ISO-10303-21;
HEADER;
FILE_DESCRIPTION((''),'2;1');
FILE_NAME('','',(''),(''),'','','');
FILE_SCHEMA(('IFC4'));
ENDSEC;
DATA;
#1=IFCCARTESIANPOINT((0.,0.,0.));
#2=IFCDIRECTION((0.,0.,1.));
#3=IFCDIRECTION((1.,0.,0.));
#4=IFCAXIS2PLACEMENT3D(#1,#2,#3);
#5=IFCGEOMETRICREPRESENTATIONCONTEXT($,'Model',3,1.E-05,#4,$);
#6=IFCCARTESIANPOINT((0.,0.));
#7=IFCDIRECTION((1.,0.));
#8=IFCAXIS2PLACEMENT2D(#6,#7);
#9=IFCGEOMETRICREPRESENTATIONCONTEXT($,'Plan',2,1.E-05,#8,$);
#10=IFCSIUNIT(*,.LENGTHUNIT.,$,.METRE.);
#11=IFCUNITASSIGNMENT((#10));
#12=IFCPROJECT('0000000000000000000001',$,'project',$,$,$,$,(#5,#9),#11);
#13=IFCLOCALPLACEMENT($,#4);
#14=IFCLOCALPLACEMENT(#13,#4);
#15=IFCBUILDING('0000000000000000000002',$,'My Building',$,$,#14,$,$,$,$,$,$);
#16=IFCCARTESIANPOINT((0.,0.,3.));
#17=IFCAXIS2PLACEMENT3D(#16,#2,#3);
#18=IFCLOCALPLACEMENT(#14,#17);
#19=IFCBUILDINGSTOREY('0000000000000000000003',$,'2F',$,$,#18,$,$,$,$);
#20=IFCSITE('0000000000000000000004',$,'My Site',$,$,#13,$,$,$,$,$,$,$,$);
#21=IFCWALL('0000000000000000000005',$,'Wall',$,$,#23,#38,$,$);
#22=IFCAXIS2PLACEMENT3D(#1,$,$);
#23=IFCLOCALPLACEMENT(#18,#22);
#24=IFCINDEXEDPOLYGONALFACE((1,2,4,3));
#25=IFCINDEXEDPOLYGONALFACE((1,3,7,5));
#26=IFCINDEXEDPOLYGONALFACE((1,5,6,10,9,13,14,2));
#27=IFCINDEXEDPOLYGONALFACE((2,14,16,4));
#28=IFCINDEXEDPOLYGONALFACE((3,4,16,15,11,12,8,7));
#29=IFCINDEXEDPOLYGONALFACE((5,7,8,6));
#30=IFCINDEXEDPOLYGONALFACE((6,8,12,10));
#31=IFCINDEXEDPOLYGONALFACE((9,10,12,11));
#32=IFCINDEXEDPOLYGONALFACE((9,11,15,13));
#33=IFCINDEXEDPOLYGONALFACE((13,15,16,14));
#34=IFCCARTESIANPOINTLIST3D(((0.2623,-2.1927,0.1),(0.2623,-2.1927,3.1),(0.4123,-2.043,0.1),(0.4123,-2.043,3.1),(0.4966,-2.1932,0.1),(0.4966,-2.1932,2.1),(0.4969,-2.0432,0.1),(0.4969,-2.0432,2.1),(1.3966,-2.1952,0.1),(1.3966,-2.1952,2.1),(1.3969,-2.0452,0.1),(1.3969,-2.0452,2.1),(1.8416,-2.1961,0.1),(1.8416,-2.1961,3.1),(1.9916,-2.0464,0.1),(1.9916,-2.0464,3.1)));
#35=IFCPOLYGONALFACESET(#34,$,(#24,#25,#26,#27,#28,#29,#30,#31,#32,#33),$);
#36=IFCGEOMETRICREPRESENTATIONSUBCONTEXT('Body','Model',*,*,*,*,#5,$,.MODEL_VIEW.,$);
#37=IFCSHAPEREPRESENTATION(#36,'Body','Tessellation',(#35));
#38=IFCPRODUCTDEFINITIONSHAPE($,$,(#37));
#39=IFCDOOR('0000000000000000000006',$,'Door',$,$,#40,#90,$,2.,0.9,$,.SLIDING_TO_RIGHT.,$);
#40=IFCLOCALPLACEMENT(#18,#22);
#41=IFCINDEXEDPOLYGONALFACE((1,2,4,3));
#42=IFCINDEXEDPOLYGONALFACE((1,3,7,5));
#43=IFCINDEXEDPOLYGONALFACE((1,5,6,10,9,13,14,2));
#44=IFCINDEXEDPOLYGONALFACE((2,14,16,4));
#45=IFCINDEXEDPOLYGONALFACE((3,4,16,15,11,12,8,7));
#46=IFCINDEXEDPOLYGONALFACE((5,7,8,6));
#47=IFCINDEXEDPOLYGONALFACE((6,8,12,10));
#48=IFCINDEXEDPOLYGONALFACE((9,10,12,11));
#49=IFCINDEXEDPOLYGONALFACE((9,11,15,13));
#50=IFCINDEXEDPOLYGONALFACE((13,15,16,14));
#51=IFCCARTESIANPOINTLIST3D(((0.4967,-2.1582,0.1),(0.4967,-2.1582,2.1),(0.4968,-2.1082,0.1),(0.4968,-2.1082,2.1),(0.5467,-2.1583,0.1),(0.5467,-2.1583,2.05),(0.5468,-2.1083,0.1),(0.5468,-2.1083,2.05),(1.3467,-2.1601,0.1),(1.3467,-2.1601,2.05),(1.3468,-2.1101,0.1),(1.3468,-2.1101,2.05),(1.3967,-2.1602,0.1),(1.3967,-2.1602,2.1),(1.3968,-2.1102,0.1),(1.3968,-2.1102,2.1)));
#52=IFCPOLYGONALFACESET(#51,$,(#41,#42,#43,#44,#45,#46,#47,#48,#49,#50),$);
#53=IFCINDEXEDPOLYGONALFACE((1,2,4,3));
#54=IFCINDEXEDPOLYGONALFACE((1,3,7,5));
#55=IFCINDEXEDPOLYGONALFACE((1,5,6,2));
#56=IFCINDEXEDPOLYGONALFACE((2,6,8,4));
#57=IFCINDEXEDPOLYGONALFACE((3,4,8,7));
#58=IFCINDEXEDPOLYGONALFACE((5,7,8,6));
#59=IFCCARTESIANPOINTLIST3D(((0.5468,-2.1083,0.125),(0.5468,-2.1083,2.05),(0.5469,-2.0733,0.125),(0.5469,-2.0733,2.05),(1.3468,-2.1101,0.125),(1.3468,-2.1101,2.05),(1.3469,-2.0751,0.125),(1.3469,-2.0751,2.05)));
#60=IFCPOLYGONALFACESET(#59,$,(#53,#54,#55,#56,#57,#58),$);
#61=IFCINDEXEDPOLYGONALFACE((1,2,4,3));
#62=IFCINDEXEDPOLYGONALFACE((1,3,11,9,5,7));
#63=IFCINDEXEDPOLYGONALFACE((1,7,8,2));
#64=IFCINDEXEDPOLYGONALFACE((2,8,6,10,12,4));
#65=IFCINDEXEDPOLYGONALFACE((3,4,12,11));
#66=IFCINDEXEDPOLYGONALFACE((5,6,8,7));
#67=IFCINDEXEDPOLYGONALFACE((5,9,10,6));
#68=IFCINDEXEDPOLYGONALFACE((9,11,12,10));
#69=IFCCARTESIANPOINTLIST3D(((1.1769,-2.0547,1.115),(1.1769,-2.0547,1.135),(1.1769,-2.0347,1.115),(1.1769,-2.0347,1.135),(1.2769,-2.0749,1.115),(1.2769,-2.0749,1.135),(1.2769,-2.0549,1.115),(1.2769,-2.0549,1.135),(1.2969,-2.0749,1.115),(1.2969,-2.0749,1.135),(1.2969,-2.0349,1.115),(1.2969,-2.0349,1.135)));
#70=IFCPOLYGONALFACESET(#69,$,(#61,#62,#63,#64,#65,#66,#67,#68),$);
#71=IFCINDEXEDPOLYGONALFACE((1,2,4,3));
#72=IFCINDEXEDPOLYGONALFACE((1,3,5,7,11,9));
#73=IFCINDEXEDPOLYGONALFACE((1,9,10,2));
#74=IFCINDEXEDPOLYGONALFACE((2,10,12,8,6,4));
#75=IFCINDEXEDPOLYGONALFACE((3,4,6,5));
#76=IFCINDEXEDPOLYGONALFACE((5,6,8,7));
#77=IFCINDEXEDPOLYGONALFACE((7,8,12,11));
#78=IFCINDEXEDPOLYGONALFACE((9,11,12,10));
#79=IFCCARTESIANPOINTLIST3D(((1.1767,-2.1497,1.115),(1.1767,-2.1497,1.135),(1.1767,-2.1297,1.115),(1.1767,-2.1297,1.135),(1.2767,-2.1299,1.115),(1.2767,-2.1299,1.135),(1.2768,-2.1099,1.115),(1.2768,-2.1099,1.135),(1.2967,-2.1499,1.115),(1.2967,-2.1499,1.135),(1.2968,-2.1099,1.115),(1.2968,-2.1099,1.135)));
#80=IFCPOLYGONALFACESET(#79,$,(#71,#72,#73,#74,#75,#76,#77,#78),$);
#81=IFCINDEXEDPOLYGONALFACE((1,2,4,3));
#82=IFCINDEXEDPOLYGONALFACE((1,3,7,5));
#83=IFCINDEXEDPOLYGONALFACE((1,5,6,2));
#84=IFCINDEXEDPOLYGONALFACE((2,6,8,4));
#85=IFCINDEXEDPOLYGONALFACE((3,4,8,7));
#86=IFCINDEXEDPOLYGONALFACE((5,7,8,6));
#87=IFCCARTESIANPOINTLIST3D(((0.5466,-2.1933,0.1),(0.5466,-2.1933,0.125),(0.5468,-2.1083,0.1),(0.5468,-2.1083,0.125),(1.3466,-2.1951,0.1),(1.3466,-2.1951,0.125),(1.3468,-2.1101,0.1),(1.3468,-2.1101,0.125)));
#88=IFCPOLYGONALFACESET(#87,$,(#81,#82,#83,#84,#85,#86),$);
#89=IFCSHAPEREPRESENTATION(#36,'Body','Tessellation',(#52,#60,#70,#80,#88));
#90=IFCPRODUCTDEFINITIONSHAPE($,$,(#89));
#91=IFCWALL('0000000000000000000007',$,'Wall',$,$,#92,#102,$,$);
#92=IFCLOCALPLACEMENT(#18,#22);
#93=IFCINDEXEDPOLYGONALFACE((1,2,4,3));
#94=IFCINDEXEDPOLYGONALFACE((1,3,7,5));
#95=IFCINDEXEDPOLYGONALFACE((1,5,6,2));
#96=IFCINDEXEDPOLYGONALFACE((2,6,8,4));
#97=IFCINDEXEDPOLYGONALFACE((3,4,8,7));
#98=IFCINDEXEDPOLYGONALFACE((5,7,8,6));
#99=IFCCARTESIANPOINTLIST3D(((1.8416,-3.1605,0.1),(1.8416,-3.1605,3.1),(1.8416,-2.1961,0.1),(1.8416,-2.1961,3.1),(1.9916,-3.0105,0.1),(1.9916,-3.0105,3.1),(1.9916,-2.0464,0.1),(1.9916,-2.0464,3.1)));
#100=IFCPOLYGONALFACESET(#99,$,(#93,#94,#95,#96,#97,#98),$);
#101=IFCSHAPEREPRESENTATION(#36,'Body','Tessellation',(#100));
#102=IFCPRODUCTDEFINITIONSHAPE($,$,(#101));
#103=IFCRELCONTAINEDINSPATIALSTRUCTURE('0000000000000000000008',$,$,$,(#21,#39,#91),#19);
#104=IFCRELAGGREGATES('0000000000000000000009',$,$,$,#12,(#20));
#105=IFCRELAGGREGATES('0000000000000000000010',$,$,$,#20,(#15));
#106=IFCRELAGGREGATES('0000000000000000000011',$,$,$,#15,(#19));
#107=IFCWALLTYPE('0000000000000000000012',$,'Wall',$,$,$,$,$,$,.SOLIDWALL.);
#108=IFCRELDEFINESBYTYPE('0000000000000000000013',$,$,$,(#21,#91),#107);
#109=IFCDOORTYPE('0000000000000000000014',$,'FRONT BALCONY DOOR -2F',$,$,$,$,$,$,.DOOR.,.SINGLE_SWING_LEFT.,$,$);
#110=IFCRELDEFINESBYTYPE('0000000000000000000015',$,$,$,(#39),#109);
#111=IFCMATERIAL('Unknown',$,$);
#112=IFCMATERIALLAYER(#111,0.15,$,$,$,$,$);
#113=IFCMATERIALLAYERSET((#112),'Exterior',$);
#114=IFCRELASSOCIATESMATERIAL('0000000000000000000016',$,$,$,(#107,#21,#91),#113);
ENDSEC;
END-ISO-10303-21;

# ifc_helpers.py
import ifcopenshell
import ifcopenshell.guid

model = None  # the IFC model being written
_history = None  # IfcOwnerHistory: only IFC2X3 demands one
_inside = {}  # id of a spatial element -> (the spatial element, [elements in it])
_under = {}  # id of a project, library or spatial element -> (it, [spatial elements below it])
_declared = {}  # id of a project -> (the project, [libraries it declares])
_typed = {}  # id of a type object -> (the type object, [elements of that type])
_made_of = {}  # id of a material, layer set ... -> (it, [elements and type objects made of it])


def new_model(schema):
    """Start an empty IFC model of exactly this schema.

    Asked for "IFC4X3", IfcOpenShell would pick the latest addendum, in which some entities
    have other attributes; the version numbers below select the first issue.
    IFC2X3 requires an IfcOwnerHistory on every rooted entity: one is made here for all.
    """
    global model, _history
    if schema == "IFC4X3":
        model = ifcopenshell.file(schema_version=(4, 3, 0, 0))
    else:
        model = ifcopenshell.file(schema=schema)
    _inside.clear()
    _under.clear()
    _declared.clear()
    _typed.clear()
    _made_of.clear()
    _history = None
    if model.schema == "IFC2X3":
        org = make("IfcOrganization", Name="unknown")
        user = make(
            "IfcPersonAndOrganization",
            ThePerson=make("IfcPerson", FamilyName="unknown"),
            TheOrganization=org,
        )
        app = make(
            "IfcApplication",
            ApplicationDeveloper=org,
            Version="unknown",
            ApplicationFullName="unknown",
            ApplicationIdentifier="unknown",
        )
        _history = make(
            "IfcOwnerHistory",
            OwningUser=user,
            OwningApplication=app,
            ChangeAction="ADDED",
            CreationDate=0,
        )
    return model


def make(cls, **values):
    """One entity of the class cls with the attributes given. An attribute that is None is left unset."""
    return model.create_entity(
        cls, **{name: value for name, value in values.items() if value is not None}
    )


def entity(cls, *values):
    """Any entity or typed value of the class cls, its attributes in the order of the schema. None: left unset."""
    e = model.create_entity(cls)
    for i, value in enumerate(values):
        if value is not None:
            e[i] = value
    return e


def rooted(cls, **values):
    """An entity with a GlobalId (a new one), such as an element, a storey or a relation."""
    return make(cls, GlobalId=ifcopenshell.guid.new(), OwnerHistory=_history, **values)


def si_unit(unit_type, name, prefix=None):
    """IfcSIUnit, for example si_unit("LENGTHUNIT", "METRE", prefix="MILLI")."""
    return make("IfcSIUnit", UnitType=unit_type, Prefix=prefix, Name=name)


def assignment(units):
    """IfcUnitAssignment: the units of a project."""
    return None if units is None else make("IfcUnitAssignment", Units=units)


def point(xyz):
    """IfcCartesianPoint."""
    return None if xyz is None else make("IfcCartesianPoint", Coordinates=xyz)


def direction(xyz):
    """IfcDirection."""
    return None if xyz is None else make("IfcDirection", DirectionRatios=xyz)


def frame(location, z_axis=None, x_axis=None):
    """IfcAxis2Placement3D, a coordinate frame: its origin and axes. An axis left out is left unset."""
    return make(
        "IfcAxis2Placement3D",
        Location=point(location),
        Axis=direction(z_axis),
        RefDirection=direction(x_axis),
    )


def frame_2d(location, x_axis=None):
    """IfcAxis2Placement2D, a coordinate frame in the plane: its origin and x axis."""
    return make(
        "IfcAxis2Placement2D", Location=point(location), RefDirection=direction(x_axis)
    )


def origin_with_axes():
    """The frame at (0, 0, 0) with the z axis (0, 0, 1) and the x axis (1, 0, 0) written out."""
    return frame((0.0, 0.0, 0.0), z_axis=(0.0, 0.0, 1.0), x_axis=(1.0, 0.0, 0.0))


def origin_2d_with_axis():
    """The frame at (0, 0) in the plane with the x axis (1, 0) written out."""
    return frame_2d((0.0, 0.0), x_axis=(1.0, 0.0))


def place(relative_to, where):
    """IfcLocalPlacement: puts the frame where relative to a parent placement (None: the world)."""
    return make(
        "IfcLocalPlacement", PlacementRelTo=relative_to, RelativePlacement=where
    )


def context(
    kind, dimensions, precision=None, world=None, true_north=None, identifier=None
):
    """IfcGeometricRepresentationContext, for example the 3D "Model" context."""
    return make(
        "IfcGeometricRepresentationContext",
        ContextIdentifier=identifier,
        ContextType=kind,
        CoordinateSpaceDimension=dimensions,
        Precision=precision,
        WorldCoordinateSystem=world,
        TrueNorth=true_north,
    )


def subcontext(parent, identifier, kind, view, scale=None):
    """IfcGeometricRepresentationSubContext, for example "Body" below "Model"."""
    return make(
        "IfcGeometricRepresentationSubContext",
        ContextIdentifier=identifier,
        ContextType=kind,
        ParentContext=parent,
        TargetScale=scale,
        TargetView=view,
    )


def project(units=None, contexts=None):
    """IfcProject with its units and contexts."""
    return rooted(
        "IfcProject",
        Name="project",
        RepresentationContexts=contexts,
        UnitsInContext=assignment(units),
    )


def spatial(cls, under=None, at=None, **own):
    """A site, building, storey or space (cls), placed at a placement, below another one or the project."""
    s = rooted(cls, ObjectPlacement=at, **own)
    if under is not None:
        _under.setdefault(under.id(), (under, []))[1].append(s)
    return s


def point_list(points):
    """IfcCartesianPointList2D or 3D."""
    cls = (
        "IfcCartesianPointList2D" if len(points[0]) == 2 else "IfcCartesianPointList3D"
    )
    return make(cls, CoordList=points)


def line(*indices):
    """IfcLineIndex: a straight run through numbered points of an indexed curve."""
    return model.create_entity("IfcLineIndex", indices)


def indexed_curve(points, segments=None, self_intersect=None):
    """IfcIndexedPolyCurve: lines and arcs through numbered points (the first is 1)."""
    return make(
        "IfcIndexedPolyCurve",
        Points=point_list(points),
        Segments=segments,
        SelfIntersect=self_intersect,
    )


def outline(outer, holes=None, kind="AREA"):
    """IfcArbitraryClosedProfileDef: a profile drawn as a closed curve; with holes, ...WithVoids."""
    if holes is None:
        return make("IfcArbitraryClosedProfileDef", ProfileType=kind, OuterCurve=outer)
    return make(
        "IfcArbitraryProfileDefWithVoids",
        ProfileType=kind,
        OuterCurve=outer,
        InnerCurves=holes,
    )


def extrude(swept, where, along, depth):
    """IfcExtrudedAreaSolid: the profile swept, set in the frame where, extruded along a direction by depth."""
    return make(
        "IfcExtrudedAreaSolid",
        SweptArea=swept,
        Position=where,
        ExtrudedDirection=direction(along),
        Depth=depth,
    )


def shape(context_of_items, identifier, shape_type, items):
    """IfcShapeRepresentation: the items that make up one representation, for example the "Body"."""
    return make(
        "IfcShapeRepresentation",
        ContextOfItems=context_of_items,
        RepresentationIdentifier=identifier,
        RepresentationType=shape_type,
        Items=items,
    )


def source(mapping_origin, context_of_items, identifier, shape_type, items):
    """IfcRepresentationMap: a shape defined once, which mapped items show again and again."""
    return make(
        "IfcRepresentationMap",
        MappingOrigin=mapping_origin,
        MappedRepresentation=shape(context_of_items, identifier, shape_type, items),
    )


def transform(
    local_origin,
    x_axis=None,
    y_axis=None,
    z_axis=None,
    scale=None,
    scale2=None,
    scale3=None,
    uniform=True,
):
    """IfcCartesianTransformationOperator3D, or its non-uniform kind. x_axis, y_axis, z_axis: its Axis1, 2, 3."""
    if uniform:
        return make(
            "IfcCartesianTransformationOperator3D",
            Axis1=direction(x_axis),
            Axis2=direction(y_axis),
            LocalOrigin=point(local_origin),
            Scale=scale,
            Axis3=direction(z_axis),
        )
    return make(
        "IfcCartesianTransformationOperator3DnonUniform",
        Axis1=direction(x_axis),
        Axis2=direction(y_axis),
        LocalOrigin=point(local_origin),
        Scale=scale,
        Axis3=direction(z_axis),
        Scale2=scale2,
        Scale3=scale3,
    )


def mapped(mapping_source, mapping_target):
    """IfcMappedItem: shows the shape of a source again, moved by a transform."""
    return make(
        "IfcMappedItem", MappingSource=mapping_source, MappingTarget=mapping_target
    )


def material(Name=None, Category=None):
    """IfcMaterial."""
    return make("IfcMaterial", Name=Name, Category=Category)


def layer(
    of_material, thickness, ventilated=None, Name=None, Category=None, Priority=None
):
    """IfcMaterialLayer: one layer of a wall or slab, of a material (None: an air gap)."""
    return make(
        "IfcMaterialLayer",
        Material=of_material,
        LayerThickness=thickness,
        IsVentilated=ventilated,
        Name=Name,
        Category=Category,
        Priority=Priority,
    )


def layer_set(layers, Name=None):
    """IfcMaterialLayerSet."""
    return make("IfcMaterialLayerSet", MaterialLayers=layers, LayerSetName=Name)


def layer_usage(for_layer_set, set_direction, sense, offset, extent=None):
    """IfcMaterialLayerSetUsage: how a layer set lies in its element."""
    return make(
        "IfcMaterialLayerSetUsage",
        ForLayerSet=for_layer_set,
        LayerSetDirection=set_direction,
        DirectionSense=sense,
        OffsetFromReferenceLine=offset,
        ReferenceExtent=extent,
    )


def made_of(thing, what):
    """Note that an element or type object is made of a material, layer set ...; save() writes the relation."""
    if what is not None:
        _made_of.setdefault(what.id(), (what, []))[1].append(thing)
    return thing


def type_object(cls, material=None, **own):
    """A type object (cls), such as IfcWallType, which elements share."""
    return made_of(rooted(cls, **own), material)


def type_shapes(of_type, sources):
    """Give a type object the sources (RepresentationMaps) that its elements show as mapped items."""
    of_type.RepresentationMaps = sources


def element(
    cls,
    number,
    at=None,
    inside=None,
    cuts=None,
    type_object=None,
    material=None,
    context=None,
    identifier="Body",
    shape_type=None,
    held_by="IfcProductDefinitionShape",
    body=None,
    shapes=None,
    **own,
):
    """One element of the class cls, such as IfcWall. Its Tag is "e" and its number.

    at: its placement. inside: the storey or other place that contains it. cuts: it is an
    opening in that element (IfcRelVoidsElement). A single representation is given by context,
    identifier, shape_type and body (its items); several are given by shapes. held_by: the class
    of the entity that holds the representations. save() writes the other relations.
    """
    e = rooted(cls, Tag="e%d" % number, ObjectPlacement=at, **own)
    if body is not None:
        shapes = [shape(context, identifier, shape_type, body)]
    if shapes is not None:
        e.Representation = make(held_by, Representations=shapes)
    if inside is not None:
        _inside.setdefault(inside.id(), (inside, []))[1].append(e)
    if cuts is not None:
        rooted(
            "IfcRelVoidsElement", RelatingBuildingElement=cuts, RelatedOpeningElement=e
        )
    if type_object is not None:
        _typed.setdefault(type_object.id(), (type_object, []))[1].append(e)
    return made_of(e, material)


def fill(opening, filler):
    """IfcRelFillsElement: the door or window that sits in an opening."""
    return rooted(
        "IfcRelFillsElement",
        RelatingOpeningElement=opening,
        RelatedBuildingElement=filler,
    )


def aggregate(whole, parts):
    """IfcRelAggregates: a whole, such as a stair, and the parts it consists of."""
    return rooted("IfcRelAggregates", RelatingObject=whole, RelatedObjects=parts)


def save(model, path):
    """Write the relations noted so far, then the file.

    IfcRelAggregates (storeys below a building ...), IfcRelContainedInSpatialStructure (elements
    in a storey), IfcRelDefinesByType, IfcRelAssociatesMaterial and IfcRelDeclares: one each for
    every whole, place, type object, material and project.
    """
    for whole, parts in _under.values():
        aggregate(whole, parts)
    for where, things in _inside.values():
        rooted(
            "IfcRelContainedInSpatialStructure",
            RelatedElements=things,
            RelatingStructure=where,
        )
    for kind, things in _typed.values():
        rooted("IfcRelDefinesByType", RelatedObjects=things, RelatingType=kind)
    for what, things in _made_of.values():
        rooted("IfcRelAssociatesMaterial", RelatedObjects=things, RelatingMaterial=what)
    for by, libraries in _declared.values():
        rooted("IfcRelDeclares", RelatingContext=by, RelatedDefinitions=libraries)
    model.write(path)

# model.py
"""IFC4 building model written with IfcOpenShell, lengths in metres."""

from ifc_helpers import new_model, entity, si_unit, frame, origin_with_axes, origin_2d_with_axis, place, context, subcontext, project, spatial, line, indexed_curve, outline, extrude, shape, source, transform, mapped, material, layer, layer_set, layer_usage, type_object, type_shapes, element, fill, save


model = new_model("IFC4")

# Units and contexts
model_context = context("Model", 3, precision=1e-05, world=origin_with_axes())
plan_context = context("Plan", 2, precision=1e-05, world=origin_2d_with_axis())
body_context_1 = subcontext(model_context, "Body", "Model", "MODEL_VIEW")
body_context_2 = subcontext(plan_context, "Body", "Plan", "PLAN_VIEW")
ifc_project = project(units=[si_unit("LENGTHUNIT", "METRE")], contexts=[model_context, plan_context])

# Site, building, storey
site_placement = place(None, origin_with_axes())
site = spatial("IfcSite", under=ifc_project, at=site_placement, Name="My Site")
building_placement = place(site_placement, origin_with_axes())
building = spatial("IfcBuilding", under=site, at=building_placement, Name="My Building")
storey_placement = place(building_placement, frame((0.0, 0.0, 3.0), z_axis=(0.0, 0.0, 1.0), x_axis=(1.0, 0.0, 0.0)))
storey = spatial("IfcBuildingStorey", under=building, at=storey_placement, Name="2F")

# Shared definitions
ifc_material = material(Name="Unknown")

# Shared definitions
ifc_layer_1 = layer(ifc_material, 0.15)
ifc_layer_set_1 = layer_set([ifc_layer_1], Name="Exterior")
wall_type_1 = type_object("IfcWallType", Name="Wall", PredefinedType="SOLIDWALL", material=ifc_layer_set_1)

# Wall, opening, door
ifc_layer_usage_1 = layer_usage(ifc_layer_set_1, "AXIS2", "POSITIVE", 0.0)
wall_1_placement = place(storey_placement, frame((0.2623, -2.1927, 0.1), z_axis=(0.0, 0.0, 1.0), x_axis=(0.999998, -0.002147, 0.0)))
wall_1 = element("IfcWall", 1, at=wall_1_placement, inside=storey, type_object=wall_type_1, material=ifc_layer_usage_1, Name="Wall", context=body_context_1, shape_type="SweptSolid", body=[
    extrude(outline(indexed_curve([(0.0, 0.0), (0.1497, 0.15), (1.729, 0.15), (1.5793, 0.0)], segments=[line(1, 2, 3, 4, 1)])), origin_with_axes(), (0.0, 0.0, 1.0), 3.0),
])
shared_shape_1 = source(origin_with_axes(), body_context_1, "Body", "SweptSolid", [
    extrude(outline(indexed_curve([(0.0, 0.0), (0.9, 0.0), (0.9, 2.0), (0.0, 2.0)], segments=[line(1, 2, 3, 4, 1)])), frame((0.0, -0.6, 0.0), z_axis=(0.0, -1.0, 0.0), x_axis=(1.0, 0.0, 0.0)), (0.0, 0.0, -1.0), 1.2),
])
opening_1_placement = place(wall_1_placement, frame((1.1343, 0.085, 0.0), z_axis=(0.0, 0.0, 1.0), x_axis=(-1.0, 0.0, 0.0)))
opening_1 = element("IfcOpeningElement", 2, at=opening_1_placement, cuts=wall_1, PredefinedType="OPENING", context=body_context_1, shape_type="MappedRepresentation", body=[
    mapped(shared_shape_1, transform((0.0, 0.0, 0.0), x_axis=(1.0, 0.0, 0.0), y_axis=(0.0, 1.0, 0.0), z_axis=(0.0, 0.0, 1.0), scale=1.0)),
])
door_type_1 = type_object("IfcDoorType", Name="FRONT BALCONY DOOR -2F", OperationType="SINGLE_SWING_LEFT", PredefinedType="DOOR")
shared_shape_2 = source(origin_with_axes(), body_context_1, "Body", "SweptSolid", [
    extrude(outline(indexed_curve([(0.0, 0.0), (0.0, 2.0), (0.9, 2.0), (0.9, 0.0), (0.85, 0.0), (0.85, 1.95), (0.05, 1.95), (0.05, 0.0)], segments=[line(1, 2, 3, 4, 5, 6, 7, 8, 1)])), frame((0.0, 0.0, 0.0), z_axis=(0.0, -1.0, 0.0), x_axis=(1.0, 0.0, 0.0)), (0.0, 0.0, -1.0), 0.05),
    extrude(outline(indexed_curve([(0.0, 0.0), (0.8, 0.0), (0.8, 0.035), (0.0, 0.035)], segments=[line(1, 2, 3, 4, 1)])), frame((0.05, -0.035, 0.025), z_axis=(0.0, 0.0, 1.0), x_axis=(1.0, 0.0, 0.0)), (0.0, 0.0, 1.0), 1.925),
    extrude(outline(indexed_curve([(0.0, 0.0), (0.0, -0.04), (0.12, -0.04), (0.12, -0.02), (0.02, -0.02), (0.02, 0.0)], segments=[line(1, 2, 3, 4, 5, 6, 1)])), frame((0.1, -0.035, 1.015), z_axis=(0.0, 0.0, 1.0), x_axis=(1.0, 0.0, 0.0)), (0.0, 0.0, 1.0), 0.02),
    extrude(outline(indexed_curve([(0.0, 0.0), (0.0, 0.04), (0.12, 0.04), (0.12, 0.02), (0.02, 0.02), (0.02, 0.0)], segments=[line(1, 2, 3, 4, 5, 6, 1)])), frame((0.1, 0.0, 1.015), z_axis=(0.0, 0.0, 1.0), x_axis=(1.0, 0.0, 0.0)), (0.0, 0.0, 1.0), 0.02),
    extrude(outline(indexed_curve([(0.0, 0.0), (0.8, 0.0), (0.8, 0.085), (0.0, 0.085)], segments=[line(1, 2, 3, 4, 1)])), frame((0.05, 0.0, 0.0), z_axis=(0.0, 0.0, 1.0), x_axis=(1.0, 0.0, 0.0)), (0.0, 0.0, 1.0), 0.025),
])
shared_shape_3 = source(origin_with_axes(), body_context_2, "Body", "Curve2D", [
    entity("IfcIndexedPolyCurve", entity("IfcCartesianPointList2D", [[0.0, 0.0], [0.05, 0.0], [0.05, 0.05], [0.0, 0.05]]), [entity("IfcLineIndex", [1, 2, 3, 4, 1])]),
    entity("IfcIndexedPolyCurve", entity("IfcCartesianPointList2D", [[0.9, 0.0], [0.85, 0.0], [0.85, 0.05], [0.9, 0.05]]), [entity("IfcLineIndex", [1, 2, 3, 4, 1])]),
    entity("IfcIndexedPolyCurve", entity("IfcCartesianPointList2D", [[1.25, -0.035], [0.45, -0.035], [0.45, 0.0], [1.25, 0.0]]), [entity("IfcLineIndex", [1, 2, 3, 4, 1])]),
])
type_shapes(door_type_1, [shared_shape_2, shared_shape_3])
door_1_placement = place(opening_1_placement, frame((0.0, 0.0, 0.0), z_axis=(0.0, 0.0, 1.0), x_axis=(1.0, 0.0, 0.0)))
door_1 = element("IfcDoor", 3, at=door_1_placement, inside=storey, type_object=door_type_1, Name="Door", OperationType="SLIDING_TO_RIGHT", OverallHeight=2.0, OverallWidth=0.9, shapes=[
    shape(body_context_1, "Body", "MappedRepresentation", [mapped(shared_shape_2, transform((0.0, 0.0, 0.0), x_axis=(1.0, 0.0, 0.0), y_axis=(0.0, 1.0, 0.0), z_axis=(0.0, 0.0, 1.0), scale=1.0))]),
    shape(body_context_2, "Body", "MappedRepresentation", [mapped(shared_shape_3, transform((0.0, 0.0, 0.0), x_axis=(1.0, 0.0, 0.0), y_axis=(0.0, 1.0, 0.0), z_axis=(0.0, 0.0, 1.0), scale=1.0))]),
])
fill(opening_1, door_1)

# Wall
ifc_layer_usage_2 = layer_usage(ifc_layer_set_1, "AXIS2", "POSITIVE", 0.0)
wall_2_placement = place(storey_placement, frame((1.8416, -2.1961, 0.1), z_axis=(0.0, 0.0, 1.0), x_axis=(0.0, -1.0, 0.0)))
element("IfcWall", 4, at=wall_2_placement, inside=storey, type_object=wall_type_1, material=ifc_layer_usage_2, Name="Wall", context=body_context_1, shape_type="SweptSolid", body=[
    extrude(outline(indexed_curve([(0.0, 0.0), (-0.1497, 0.15), (0.8144, 0.15), (0.9644, 0.0)], segments=[line(1, 2, 3, 4, 1)])), origin_with_axes(), (0.0, 0.0, 1.0), 3.0),
])

save(model, "model.ifc")
